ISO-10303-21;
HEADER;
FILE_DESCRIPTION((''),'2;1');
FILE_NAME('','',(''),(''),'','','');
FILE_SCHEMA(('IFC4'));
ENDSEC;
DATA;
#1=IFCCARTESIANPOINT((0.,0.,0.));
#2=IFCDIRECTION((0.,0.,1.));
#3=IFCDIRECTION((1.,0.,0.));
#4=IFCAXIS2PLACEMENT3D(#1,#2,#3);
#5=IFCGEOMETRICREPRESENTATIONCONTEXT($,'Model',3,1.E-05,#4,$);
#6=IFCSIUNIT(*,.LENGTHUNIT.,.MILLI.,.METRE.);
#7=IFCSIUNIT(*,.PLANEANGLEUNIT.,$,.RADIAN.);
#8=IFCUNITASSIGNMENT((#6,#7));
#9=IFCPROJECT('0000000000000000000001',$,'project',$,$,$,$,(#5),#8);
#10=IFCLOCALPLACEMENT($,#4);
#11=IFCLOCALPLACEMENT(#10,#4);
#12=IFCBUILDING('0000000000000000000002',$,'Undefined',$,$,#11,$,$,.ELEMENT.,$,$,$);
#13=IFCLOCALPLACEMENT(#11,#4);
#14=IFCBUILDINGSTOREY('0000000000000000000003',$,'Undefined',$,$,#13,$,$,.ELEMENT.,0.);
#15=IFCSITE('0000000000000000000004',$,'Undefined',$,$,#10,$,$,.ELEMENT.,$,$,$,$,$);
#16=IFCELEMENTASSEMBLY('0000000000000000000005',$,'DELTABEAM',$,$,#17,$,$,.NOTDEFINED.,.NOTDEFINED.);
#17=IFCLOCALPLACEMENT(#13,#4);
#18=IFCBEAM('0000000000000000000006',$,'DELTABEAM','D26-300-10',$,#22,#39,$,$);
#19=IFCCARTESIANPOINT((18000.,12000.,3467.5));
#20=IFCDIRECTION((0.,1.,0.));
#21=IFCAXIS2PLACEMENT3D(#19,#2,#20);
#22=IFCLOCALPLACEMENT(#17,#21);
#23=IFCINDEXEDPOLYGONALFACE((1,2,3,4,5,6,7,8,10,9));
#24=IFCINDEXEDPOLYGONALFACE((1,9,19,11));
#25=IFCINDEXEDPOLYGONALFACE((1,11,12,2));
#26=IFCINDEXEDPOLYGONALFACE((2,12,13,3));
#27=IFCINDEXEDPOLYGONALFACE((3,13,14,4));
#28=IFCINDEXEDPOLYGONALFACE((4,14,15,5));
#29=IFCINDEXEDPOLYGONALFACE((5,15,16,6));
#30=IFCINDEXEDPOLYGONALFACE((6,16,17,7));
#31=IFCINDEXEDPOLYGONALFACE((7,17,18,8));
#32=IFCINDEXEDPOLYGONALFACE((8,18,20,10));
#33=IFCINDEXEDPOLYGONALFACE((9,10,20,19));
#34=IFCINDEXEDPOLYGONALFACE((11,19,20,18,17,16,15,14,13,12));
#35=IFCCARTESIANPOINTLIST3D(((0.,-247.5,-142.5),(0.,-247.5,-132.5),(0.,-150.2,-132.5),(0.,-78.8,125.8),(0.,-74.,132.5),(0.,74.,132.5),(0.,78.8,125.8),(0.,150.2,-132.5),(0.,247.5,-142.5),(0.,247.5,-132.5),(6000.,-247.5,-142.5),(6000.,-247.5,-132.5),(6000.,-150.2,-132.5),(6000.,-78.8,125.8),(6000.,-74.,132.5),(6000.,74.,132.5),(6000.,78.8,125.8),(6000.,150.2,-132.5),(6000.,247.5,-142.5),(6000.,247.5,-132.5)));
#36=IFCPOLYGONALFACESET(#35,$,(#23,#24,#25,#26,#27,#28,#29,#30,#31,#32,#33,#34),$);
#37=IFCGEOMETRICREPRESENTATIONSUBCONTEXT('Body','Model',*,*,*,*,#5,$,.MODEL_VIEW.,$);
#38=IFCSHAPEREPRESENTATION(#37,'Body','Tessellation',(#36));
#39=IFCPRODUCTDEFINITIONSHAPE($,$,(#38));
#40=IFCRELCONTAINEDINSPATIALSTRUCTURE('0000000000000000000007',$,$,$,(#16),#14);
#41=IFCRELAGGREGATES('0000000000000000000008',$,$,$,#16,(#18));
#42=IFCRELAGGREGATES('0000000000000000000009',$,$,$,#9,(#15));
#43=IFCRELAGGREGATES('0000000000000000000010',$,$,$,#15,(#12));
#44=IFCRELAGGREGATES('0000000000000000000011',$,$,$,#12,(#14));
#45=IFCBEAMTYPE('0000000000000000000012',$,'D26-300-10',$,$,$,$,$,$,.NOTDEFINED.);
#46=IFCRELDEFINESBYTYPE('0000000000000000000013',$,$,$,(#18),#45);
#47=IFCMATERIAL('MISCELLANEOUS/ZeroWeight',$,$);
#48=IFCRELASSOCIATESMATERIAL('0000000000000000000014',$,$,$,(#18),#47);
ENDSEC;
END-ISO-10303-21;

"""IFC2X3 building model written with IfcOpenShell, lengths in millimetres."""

from ifc_helpers import new_model, si_unit, frame, origin_with_axes, place, context, subcontext, project, spatial, polyline, outline, extrude, material, type_object, element, aggregate, save


model = new_model("IFC2X3")

# Units and contexts
model_context = context("Model", 3, precision=1e-05, world=origin_with_axes())
body_context = subcontext(model_context, "Body", "Model", "MODEL_VIEW")
ifc_project = project(units=[si_unit("LENGTHUNIT", "METRE", prefix="MILLI"), si_unit("PLANEANGLEUNIT", "RADIAN")], contexts=[model_context])

# Site, building, storey
site_placement = place(None, origin_with_axes())
site = spatial("IfcSite", under=ifc_project, at=site_placement, Name="Undefined", CompositionType="ELEMENT")
building_placement = place(site_placement, origin_with_axes())
building = spatial("IfcBuilding", under=site, at=building_placement, Name="Undefined", CompositionType="ELEMENT")
storey_placement = place(building_placement, origin_with_axes())
storey = spatial("IfcBuildingStorey", under=building, at=storey_placement, Name="Undefined", CompositionType="ELEMENT", Elevation=0.0)

# Element assembly, beam
assembly_1_placement = place(storey_placement, origin_with_axes())
assembly_1 = element("IfcElementAssembly", 1, at=assembly_1_placement, inside=storey, Name="DELTABEAM", AssemblyPlace="NOTDEFINED", PredefinedType="NOTDEFINED")
ifc_material_1 = material(Name="MISCELLANEOUS/ZeroWeight")
beam_type_1 = type_object("IfcBeamType", Name="D26-300-10", PredefinedType="NOTDEFINED")
beam_1_placement = place(assembly_1_placement, frame((18000.0, 12000.0, 3467.5), z_axis=(0.0, 0.0, 1.0), x_axis=(0.0, 1.0, 0.0)))
beam_1 = element("IfcBeam", 2, at=beam_1_placement, type_object=beam_type_1, material=ifc_material_1, Name="DELTABEAM", Description="D26-300-10", context=body_context, shape_type="SweptSolid", body=[
    extrude(outline(polyline([(-75.1, 120.5), (-145.0, -132.5), (247.5, -132.5), (247.5, -142.5), (-247.5, -142.5), (-247.5, -132.5), (-150.2, -132.5), (-78.8, 125.8), (-74.0, 132.5), (74.0, 132.5), (78.8, 125.8), (150.2, -132.5), (145.0, -132.5), (75.1, 120.5), (-75.1, 120.5)])), frame((6000.0, 0.0, 0.0), z_axis=(-1.0, 0.0, 0.0), x_axis=(0.0, -1.0, 0.0)), (0.0, 0.0, 1.0), 6000.0),
])
aggregate(assembly_1, [beam_1])

save(model, "model.ifc")
